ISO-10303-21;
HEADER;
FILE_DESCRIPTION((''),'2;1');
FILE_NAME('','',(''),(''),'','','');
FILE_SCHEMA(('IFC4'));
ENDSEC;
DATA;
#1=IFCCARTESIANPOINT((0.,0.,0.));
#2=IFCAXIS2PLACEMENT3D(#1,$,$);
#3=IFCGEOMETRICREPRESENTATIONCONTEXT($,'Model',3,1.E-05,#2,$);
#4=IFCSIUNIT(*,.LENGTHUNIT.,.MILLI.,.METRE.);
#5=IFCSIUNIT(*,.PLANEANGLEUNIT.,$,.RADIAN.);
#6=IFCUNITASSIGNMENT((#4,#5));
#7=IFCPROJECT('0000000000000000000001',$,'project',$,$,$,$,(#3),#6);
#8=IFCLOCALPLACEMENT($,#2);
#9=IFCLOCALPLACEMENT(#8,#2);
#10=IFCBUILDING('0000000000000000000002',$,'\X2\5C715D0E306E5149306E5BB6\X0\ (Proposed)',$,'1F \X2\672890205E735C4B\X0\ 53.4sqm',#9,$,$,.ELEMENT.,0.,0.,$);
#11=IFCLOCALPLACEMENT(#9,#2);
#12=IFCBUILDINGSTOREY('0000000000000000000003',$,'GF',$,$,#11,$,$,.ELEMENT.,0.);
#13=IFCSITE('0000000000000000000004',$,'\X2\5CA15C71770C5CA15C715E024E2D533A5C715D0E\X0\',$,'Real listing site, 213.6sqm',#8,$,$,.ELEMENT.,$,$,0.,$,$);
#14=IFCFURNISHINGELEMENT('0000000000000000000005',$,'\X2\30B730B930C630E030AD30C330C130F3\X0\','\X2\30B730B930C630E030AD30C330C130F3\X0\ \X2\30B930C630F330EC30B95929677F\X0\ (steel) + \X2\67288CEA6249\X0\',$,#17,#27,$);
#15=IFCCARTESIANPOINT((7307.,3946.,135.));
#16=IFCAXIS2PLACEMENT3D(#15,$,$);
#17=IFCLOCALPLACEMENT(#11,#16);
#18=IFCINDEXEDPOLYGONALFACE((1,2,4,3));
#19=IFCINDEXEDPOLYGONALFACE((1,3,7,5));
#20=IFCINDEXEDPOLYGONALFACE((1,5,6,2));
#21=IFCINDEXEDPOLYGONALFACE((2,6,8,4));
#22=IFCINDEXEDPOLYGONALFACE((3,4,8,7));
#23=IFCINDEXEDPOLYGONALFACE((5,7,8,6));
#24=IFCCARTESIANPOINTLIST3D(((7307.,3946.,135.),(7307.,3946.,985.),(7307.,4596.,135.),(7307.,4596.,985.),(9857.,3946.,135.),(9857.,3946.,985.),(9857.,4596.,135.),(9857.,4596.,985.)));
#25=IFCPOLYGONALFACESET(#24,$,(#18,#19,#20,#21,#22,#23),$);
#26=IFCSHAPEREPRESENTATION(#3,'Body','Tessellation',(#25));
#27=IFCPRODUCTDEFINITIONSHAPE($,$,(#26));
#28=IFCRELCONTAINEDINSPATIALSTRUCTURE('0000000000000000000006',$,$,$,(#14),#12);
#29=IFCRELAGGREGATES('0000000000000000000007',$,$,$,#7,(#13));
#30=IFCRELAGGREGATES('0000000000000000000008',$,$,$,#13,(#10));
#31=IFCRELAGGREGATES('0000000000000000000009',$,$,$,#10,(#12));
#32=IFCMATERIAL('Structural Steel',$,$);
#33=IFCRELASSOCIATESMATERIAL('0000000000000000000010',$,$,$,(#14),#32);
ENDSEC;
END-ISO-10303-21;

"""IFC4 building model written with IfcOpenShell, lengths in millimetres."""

from ifc_helpers import new_model, si_unit, frame, frame_2d, origin, place, context, project, spatial, rectangle, extrude, material, element, save


model = new_model("IFC4")

# Units and contexts
model_context = context("Model", 3, precision=1e-05, world=origin())
ifc_project = project(units=[si_unit("LENGTHUNIT", "METRE", prefix="MILLI"), si_unit("PLANEANGLEUNIT", "RADIAN")], contexts=[model_context])

# Site, building, storey
site_placement = place(None, origin())
site = spatial("IfcSite", under=ifc_project, at=site_placement, Name="岡山県岡山市中区山崎", ObjectType="Real listing site, 213.6sqm", CompositionType="ELEMENT", RefElevation=0.0)
building_placement = place(site_placement, origin())
building = spatial("IfcBuilding", under=site, at=building_placement, Name="山崎の光の家 (Proposed)", ObjectType="1F 木造平屋 53.4sqm", CompositionType="ELEMENT", ElevationOfRefHeight=0.0, ElevationOfTerrain=0.0)
storey_placement = place(building_placement, origin())
storey = spatial("IfcBuildingStorey", under=building, at=storey_placement, Name="GF", CompositionType="ELEMENT", Elevation=0.0)

# Furnishing element
ifc_material_1 = material(Name="Structural Steel")
furnishing_1_placement = place(storey_placement, frame((7307.0, 3946.0, 135.0)))
element("IfcFurnishingElement", 1, at=furnishing_1_placement, inside=storey, material=ifc_material_1, Name="システムキッチン", Description="システムキッチン ステンレス天板 (steel) + 木質扉", context=model_context, shape_type="SweptSolid", body=[
    extrude(rectangle(XDim=2550.0, YDim=650.0, at=frame_2d((1275.0, 325.0))), frame((7307.0, 3946.0, 135.0)), (0.0, 0.0, 1.0), 850.0),
])

save(model, "model.ifc")
